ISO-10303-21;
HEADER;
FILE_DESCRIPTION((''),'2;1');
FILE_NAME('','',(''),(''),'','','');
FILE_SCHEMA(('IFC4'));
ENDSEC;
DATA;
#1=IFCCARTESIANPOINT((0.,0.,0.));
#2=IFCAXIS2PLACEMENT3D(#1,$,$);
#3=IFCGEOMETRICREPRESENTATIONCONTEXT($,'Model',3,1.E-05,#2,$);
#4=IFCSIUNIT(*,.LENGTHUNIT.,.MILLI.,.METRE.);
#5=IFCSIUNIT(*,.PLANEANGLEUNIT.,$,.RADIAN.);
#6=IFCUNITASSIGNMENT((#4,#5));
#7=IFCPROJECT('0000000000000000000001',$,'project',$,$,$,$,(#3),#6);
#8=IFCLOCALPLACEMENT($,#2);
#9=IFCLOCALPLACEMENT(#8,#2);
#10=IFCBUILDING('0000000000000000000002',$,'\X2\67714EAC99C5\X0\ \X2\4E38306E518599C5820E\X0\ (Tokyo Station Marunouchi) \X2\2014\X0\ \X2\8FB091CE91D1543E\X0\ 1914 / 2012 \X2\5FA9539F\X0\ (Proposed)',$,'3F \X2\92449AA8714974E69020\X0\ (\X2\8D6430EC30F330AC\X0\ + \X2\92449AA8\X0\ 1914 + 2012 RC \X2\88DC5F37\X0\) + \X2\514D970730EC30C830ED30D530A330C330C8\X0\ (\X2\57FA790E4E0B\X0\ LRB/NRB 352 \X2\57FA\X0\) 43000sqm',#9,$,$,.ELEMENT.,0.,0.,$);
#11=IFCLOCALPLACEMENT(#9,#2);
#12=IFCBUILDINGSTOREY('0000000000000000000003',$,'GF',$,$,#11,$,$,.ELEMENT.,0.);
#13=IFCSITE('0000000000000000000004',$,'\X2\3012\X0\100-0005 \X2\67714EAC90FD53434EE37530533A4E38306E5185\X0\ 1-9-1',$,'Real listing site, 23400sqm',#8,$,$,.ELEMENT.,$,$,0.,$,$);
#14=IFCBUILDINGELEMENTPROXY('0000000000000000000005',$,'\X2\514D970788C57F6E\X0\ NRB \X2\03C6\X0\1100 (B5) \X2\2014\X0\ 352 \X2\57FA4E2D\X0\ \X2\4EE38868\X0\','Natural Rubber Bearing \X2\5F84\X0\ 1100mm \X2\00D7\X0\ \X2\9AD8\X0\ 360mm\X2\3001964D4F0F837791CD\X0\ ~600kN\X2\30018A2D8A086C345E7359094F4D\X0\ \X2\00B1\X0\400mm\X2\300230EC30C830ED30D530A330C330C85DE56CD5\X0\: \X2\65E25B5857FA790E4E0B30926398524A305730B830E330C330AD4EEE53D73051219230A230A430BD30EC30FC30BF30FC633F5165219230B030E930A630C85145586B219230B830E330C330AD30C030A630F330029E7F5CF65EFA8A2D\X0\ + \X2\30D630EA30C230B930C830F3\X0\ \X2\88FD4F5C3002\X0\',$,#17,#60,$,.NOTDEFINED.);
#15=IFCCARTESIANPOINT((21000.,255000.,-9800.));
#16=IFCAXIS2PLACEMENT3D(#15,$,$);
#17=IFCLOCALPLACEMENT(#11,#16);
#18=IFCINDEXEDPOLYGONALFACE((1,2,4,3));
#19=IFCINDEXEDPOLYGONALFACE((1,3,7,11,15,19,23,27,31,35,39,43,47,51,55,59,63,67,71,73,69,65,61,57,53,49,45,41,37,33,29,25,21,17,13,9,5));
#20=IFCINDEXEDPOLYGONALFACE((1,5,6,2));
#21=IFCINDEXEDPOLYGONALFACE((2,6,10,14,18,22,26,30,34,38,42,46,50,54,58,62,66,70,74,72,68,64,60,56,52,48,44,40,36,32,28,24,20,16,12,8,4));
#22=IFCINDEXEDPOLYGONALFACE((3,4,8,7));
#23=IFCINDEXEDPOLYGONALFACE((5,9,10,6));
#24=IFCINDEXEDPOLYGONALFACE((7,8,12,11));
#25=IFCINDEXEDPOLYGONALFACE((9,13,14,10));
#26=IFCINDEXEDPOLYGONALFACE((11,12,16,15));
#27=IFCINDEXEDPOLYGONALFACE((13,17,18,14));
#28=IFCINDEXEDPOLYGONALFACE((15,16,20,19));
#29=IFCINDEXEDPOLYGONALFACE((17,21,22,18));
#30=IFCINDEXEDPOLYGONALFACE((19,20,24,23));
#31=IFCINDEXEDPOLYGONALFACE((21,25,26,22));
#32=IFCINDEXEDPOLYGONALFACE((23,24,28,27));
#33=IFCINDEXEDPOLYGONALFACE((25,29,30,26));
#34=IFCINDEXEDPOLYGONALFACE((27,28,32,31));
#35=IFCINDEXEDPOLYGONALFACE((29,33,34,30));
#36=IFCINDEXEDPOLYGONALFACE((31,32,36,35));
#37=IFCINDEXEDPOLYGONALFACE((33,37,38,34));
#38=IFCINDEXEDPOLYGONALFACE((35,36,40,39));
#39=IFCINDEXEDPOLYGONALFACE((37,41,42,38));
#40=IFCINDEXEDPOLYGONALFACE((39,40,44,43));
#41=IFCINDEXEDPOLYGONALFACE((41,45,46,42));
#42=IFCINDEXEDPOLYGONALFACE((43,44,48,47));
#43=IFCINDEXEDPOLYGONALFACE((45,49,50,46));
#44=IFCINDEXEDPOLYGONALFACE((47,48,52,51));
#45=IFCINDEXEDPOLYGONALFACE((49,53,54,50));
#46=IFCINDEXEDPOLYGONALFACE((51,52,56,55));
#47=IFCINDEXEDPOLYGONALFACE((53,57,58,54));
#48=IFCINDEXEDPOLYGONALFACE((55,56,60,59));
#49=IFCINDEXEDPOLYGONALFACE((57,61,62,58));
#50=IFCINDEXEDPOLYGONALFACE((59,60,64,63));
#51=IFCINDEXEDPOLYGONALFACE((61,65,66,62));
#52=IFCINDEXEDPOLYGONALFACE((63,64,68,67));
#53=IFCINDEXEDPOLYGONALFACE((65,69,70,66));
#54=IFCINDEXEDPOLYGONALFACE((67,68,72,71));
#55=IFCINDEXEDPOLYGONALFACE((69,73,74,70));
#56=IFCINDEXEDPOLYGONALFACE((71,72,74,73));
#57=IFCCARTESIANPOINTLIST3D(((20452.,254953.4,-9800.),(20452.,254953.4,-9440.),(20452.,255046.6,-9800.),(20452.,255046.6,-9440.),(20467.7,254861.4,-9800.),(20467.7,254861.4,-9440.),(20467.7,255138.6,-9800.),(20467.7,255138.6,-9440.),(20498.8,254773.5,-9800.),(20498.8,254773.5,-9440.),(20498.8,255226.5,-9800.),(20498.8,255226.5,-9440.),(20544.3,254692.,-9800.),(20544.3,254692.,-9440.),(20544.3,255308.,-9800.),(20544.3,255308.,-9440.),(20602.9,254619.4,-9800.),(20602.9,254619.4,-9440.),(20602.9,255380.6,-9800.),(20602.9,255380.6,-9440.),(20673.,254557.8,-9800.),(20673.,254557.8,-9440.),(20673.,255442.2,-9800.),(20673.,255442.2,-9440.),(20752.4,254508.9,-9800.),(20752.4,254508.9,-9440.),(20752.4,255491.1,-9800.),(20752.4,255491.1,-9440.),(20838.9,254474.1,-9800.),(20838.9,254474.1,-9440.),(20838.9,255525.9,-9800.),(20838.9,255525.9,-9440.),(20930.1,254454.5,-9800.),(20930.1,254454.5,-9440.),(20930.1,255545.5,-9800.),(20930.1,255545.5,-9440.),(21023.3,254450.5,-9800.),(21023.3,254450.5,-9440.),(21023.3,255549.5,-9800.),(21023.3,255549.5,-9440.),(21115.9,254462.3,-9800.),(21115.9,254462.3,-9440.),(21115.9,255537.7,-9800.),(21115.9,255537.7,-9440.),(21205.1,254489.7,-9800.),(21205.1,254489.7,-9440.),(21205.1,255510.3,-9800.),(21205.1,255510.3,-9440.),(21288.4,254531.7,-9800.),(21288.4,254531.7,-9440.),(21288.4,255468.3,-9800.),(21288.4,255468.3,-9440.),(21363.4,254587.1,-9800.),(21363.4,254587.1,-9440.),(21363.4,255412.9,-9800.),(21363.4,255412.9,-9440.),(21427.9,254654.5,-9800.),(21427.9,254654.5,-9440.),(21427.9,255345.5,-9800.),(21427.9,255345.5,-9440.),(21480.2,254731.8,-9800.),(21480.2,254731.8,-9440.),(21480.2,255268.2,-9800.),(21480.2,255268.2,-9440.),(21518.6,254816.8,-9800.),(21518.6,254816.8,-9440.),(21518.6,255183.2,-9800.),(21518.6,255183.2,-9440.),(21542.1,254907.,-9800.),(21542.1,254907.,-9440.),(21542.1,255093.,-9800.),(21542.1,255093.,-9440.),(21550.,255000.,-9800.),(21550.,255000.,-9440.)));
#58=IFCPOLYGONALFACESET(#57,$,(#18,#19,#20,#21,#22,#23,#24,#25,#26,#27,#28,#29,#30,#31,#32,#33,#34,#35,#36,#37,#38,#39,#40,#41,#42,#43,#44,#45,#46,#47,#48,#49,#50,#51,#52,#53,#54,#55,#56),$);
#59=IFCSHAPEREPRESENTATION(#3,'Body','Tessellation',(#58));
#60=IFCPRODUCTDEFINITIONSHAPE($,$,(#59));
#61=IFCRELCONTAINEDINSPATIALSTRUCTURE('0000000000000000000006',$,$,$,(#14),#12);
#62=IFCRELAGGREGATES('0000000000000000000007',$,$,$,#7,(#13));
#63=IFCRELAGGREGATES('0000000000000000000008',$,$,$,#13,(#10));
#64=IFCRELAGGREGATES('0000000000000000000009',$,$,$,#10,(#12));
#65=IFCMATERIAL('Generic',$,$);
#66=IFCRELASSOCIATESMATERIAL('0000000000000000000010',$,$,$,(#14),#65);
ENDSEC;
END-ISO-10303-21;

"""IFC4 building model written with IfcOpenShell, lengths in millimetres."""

from ifc_helpers import new_model, si_unit, frame, origin, origin_2d, place, context, project, spatial, circle, extrude, material, element, save


model = new_model("IFC4")

# Units and contexts
model_context = context("Model", 3, precision=1e-05, world=origin())
ifc_project = project(units=[si_unit("LENGTHUNIT", "METRE", prefix="MILLI"), si_unit("PLANEANGLEUNIT", "RADIAN")], contexts=[model_context])

# Site, building, storey
site_placement = place(None, origin())
site = spatial("IfcSite", under=ifc_project, at=site_placement, Name="〒100-0005 東京都千代田区丸の内 1-9-1", ObjectType="Real listing site, 23400sqm", CompositionType="ELEMENT", RefElevation=0.0)
building_placement = place(site_placement, origin())
building = spatial("IfcBuilding", under=site, at=building_placement, Name="東京駅 丸の内駅舎 (Tokyo Station Marunouchi) — 辰野金吾 1914 / 2012 復原 (Proposed)", ObjectType="3F 鉄骨煉瓦造 (赤レンガ + 鉄骨 1914 + 2012 RC 補強) + 免震レトロフィット (基礎下 LRB/NRB 352 基) 43000sqm", CompositionType="ELEMENT", ElevationOfRefHeight=0.0, ElevationOfTerrain=0.0)
storey_placement = place(building_placement, origin())
storey = spatial("IfcBuildingStorey", under=building, at=storey_placement, Name="GF", CompositionType="ELEMENT", Elevation=0.0)

# Shared definitions
ifc_material_1 = material(Name="Generic")

# Building element proxy
proxy_1_placement = place(storey_placement, frame((21000.0, 255000.0, -9800.0)))
element("IfcBuildingElementProxy", 1, at=proxy_1_placement, inside=storey, material=ifc_material_1, Name="免震装置 NRB φ1100 (B5) — 352 基中 代表", Description="Natural Rubber Bearing 径 1100mm × 高 360mm、降伏荷重 ~600kN、設計水平変位 ±400mm。レトロフィット工法: 既存基礎下を掘削しジャッキ仮受け→アイソレーター挿入→グラウト充填→ジャッキダウン。鹿島建設 + ブリヂストン 製作。", PredefinedType="NOTDEFINED", context=model_context, shape_type="SweptSolid", body=[
    extrude(circle(Radius=550.0, at=origin_2d()), frame((21000.0, 255000.0, -9800.0)), (0.0, 0.0, 1.0), 360.0),
])

save(model, "model.ifc")
